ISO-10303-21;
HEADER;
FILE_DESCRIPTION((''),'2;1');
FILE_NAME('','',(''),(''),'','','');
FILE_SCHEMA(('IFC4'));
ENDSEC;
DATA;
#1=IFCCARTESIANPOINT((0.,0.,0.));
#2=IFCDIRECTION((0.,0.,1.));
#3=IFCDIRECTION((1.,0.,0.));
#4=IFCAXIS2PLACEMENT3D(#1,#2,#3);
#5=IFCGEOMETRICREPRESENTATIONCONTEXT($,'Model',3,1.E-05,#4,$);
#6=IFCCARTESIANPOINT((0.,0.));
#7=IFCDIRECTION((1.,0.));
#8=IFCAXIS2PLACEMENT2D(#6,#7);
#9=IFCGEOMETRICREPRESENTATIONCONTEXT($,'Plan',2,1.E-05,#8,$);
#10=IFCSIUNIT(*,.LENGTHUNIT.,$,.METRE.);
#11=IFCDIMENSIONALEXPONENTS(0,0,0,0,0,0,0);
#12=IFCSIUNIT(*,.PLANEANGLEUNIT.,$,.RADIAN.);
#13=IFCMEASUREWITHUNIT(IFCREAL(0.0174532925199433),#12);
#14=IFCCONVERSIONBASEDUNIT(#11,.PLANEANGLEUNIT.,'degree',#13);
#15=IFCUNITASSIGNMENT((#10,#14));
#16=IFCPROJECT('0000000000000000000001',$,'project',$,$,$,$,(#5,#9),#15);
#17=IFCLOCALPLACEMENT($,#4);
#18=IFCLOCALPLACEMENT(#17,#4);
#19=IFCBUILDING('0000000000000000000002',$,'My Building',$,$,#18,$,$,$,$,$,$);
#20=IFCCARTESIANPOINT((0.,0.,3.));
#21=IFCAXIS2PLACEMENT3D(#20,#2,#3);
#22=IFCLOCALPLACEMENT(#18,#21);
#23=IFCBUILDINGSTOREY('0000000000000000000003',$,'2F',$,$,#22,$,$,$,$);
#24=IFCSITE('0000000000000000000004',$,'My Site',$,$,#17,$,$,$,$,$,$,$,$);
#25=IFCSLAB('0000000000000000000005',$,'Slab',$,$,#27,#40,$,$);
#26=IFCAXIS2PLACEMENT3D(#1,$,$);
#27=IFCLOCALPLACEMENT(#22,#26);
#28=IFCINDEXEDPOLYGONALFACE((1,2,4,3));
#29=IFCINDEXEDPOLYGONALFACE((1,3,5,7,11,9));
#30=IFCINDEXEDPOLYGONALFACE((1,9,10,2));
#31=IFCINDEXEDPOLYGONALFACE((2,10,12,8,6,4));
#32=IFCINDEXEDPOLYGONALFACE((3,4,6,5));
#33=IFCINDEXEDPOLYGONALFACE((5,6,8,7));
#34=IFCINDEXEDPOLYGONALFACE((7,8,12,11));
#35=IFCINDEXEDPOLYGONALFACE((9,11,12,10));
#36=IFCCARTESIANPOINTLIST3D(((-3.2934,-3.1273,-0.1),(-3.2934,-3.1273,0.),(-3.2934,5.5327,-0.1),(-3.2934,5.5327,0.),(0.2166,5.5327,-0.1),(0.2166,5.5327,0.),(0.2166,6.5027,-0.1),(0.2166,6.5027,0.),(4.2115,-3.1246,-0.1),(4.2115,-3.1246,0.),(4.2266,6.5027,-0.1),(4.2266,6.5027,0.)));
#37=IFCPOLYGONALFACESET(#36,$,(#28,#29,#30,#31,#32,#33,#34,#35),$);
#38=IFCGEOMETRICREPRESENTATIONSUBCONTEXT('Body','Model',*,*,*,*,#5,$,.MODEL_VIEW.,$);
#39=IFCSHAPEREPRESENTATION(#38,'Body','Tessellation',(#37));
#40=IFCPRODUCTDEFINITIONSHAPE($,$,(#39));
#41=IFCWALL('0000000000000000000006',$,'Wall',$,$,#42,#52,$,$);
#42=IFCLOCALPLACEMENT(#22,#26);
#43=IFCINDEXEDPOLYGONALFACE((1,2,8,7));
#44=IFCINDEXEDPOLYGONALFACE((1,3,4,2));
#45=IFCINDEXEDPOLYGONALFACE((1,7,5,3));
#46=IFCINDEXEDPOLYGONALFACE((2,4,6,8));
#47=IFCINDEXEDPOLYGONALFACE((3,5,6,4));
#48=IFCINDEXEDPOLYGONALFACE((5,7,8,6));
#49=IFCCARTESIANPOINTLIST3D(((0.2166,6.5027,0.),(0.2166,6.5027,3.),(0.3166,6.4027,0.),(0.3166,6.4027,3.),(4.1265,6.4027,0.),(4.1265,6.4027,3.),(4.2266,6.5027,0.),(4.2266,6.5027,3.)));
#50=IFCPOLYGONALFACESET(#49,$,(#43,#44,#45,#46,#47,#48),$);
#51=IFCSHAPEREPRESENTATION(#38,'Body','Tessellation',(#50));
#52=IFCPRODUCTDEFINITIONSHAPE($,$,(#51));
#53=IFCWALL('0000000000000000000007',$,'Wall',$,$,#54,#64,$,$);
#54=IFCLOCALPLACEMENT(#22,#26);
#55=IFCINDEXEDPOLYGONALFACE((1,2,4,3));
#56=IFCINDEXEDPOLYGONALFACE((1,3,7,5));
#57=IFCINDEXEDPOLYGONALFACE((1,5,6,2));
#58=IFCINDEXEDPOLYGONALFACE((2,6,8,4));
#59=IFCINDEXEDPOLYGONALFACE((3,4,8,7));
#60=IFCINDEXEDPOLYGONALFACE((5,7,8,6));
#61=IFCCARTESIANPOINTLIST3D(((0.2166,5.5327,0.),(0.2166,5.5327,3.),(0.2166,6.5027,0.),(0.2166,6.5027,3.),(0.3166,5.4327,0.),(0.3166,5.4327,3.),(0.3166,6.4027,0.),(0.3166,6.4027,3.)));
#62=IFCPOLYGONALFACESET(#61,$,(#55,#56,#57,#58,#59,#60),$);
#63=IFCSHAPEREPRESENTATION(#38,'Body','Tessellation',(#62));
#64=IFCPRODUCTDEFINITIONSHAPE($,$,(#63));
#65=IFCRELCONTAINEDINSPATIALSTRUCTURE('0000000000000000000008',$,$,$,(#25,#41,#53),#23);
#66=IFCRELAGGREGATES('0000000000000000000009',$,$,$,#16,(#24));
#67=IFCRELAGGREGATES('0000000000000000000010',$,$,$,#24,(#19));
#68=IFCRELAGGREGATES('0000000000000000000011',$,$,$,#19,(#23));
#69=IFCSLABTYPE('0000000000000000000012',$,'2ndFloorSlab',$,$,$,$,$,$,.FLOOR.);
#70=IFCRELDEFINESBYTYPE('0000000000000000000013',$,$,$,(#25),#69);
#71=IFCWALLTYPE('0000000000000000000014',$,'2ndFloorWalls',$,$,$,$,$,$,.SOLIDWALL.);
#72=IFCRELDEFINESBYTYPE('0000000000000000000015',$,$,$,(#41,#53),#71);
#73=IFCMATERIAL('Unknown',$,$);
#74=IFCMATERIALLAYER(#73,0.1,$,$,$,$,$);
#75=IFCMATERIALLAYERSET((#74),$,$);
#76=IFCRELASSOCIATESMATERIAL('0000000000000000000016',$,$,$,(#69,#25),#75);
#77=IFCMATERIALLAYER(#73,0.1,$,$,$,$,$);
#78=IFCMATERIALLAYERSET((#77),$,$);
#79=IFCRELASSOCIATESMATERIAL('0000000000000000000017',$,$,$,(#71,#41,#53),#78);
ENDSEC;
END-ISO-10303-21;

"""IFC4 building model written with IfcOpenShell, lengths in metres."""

from ifc_helpers import new_model, entity, si_unit, converted_unit, frame, origin_with_axes, origin_2d_with_axis, place, context, subcontext, project, spatial, line, indexed_curve, outline, extrude, material, layer, layer_set, layer_usage, type_object, element, save


model = new_model("IFC4")

# Units and contexts
model_context = context("Model", 3, precision=1e-05, world=origin_with_axes())
plan_context = context("Plan", 2, precision=1e-05, world=origin_2d_with_axis())
body_context_1 = subcontext(model_context, "Body", "Model", "MODEL_VIEW")
ifc_project = project(units=[si_unit("LENGTHUNIT", "METRE"), converted_unit("PLANEANGLEUNIT", "degree", entity("IfcReal", 0.0174532925199433), si_unit("PLANEANGLEUNIT", "RADIAN"), dimensions=[0, 0, 0, 0, 0, 0, 0])], contexts=[model_context, plan_context])

# Site, building, storey
site_placement = place(None, origin_with_axes())
site = spatial("IfcSite", under=ifc_project, at=site_placement, Name="My Site")
building_placement = place(site_placement, origin_with_axes())
building = spatial("IfcBuilding", under=site, at=building_placement, Name="My Building")
storey_placement = place(building_placement, frame((0.0, 0.0, 3.0), z_axis=(0.0, 0.0, 1.0), x_axis=(1.0, 0.0, 0.0)))
storey = spatial("IfcBuildingStorey", under=building, at=storey_placement, Name="2F")

# Slab
ifc_material = material(Name="Unknown")
ifc_layer_1 = layer(ifc_material, 0.1)
ifc_layer_set_1 = layer_set([ifc_layer_1])
ifc_layer_usage_1 = layer_usage(ifc_layer_set_1, "AXIS3", "POSITIVE", -0.1)
slab_type = type_object("IfcSlabType", Name="2ndFloorSlab", PredefinedType="FLOOR", material=ifc_layer_set_1)
slab_placement = place(storey_placement, frame((4.2266, 6.5027, 0.0), z_axis=(0.0, 0.0, 1.0), x_axis=(1.0, 0.0, 0.0)))
element("IfcSlab", 1, at=slab_placement, inside=storey, type_object=slab_type, material=ifc_layer_usage_1, Name="Slab", context=body_context_1, shape_type="SweptSolid", body=[
    extrude(outline(indexed_curve([(0.0, 0.0), (-4.01, 0.0), (-4.01, -0.97), (-7.52, -0.97), (-7.52, -9.63), (-0.0151, -9.6273), (0.0, 0.0)])), frame((0.0, 0.0, -0.1), z_axis=(0.0, 0.0, 1.0), x_axis=(1.0, 0.0, 0.0)), (0.0, 0.0, 1.0), 0.1),
])

# Walls
ifc_layer_2 = layer(ifc_material, 0.1)
ifc_layer_set_2 = layer_set([ifc_layer_2])
ifc_layer_usage_2 = layer_usage(ifc_layer_set_2, "AXIS2", "POSITIVE", 0.0)
wall_type = type_object("IfcWallType", Name="2ndFloorWalls", PredefinedType="SOLIDWALL", material=ifc_layer_set_2)
wall_1_placement = place(storey_placement, frame((4.2266, 6.5027, 0.0), z_axis=(0.0, 0.0, 1.0), x_axis=(-1.0, 0.0, 0.0)))
element("IfcWall", 2, at=wall_1_placement, inside=storey, type_object=wall_type, material=ifc_layer_usage_2, Name="Wall", context=body_context_1, shape_type="SweptSolid", body=[
    extrude(outline(indexed_curve([(0.0, 0.0), (0.1002, 0.1), (3.91, 0.1), (4.01, 0.0)], segments=[line(1, 2, 3, 4, 1)])), origin_with_axes(), (0.0, 0.0, 1.0), 3.0),
])
ifc_layer_usage_3 = layer_usage(ifc_layer_set_2, "AXIS2", "POSITIVE", 0.0)
wall_2_placement = place(storey_placement, frame((0.2166, 6.5027, 0.0), z_axis=(0.0, 0.0, 1.0), x_axis=(0.0, -1.0, 0.0)))
element("IfcWall", 3, at=wall_2_placement, inside=storey, type_object=wall_type, material=ifc_layer_usage_3, Name="Wall", context=body_context_1, shape_type="SweptSolid", body=[
    extrude(outline(indexed_curve([(0.0, 0.0), (0.1, 0.1), (1.07, 0.1), (0.97, 0.0)], segments=[line(1, 2, 3, 4, 1)])), origin_with_axes(), (0.0, 0.0, 1.0), 3.0),
])

save(model, "model.ifc")
